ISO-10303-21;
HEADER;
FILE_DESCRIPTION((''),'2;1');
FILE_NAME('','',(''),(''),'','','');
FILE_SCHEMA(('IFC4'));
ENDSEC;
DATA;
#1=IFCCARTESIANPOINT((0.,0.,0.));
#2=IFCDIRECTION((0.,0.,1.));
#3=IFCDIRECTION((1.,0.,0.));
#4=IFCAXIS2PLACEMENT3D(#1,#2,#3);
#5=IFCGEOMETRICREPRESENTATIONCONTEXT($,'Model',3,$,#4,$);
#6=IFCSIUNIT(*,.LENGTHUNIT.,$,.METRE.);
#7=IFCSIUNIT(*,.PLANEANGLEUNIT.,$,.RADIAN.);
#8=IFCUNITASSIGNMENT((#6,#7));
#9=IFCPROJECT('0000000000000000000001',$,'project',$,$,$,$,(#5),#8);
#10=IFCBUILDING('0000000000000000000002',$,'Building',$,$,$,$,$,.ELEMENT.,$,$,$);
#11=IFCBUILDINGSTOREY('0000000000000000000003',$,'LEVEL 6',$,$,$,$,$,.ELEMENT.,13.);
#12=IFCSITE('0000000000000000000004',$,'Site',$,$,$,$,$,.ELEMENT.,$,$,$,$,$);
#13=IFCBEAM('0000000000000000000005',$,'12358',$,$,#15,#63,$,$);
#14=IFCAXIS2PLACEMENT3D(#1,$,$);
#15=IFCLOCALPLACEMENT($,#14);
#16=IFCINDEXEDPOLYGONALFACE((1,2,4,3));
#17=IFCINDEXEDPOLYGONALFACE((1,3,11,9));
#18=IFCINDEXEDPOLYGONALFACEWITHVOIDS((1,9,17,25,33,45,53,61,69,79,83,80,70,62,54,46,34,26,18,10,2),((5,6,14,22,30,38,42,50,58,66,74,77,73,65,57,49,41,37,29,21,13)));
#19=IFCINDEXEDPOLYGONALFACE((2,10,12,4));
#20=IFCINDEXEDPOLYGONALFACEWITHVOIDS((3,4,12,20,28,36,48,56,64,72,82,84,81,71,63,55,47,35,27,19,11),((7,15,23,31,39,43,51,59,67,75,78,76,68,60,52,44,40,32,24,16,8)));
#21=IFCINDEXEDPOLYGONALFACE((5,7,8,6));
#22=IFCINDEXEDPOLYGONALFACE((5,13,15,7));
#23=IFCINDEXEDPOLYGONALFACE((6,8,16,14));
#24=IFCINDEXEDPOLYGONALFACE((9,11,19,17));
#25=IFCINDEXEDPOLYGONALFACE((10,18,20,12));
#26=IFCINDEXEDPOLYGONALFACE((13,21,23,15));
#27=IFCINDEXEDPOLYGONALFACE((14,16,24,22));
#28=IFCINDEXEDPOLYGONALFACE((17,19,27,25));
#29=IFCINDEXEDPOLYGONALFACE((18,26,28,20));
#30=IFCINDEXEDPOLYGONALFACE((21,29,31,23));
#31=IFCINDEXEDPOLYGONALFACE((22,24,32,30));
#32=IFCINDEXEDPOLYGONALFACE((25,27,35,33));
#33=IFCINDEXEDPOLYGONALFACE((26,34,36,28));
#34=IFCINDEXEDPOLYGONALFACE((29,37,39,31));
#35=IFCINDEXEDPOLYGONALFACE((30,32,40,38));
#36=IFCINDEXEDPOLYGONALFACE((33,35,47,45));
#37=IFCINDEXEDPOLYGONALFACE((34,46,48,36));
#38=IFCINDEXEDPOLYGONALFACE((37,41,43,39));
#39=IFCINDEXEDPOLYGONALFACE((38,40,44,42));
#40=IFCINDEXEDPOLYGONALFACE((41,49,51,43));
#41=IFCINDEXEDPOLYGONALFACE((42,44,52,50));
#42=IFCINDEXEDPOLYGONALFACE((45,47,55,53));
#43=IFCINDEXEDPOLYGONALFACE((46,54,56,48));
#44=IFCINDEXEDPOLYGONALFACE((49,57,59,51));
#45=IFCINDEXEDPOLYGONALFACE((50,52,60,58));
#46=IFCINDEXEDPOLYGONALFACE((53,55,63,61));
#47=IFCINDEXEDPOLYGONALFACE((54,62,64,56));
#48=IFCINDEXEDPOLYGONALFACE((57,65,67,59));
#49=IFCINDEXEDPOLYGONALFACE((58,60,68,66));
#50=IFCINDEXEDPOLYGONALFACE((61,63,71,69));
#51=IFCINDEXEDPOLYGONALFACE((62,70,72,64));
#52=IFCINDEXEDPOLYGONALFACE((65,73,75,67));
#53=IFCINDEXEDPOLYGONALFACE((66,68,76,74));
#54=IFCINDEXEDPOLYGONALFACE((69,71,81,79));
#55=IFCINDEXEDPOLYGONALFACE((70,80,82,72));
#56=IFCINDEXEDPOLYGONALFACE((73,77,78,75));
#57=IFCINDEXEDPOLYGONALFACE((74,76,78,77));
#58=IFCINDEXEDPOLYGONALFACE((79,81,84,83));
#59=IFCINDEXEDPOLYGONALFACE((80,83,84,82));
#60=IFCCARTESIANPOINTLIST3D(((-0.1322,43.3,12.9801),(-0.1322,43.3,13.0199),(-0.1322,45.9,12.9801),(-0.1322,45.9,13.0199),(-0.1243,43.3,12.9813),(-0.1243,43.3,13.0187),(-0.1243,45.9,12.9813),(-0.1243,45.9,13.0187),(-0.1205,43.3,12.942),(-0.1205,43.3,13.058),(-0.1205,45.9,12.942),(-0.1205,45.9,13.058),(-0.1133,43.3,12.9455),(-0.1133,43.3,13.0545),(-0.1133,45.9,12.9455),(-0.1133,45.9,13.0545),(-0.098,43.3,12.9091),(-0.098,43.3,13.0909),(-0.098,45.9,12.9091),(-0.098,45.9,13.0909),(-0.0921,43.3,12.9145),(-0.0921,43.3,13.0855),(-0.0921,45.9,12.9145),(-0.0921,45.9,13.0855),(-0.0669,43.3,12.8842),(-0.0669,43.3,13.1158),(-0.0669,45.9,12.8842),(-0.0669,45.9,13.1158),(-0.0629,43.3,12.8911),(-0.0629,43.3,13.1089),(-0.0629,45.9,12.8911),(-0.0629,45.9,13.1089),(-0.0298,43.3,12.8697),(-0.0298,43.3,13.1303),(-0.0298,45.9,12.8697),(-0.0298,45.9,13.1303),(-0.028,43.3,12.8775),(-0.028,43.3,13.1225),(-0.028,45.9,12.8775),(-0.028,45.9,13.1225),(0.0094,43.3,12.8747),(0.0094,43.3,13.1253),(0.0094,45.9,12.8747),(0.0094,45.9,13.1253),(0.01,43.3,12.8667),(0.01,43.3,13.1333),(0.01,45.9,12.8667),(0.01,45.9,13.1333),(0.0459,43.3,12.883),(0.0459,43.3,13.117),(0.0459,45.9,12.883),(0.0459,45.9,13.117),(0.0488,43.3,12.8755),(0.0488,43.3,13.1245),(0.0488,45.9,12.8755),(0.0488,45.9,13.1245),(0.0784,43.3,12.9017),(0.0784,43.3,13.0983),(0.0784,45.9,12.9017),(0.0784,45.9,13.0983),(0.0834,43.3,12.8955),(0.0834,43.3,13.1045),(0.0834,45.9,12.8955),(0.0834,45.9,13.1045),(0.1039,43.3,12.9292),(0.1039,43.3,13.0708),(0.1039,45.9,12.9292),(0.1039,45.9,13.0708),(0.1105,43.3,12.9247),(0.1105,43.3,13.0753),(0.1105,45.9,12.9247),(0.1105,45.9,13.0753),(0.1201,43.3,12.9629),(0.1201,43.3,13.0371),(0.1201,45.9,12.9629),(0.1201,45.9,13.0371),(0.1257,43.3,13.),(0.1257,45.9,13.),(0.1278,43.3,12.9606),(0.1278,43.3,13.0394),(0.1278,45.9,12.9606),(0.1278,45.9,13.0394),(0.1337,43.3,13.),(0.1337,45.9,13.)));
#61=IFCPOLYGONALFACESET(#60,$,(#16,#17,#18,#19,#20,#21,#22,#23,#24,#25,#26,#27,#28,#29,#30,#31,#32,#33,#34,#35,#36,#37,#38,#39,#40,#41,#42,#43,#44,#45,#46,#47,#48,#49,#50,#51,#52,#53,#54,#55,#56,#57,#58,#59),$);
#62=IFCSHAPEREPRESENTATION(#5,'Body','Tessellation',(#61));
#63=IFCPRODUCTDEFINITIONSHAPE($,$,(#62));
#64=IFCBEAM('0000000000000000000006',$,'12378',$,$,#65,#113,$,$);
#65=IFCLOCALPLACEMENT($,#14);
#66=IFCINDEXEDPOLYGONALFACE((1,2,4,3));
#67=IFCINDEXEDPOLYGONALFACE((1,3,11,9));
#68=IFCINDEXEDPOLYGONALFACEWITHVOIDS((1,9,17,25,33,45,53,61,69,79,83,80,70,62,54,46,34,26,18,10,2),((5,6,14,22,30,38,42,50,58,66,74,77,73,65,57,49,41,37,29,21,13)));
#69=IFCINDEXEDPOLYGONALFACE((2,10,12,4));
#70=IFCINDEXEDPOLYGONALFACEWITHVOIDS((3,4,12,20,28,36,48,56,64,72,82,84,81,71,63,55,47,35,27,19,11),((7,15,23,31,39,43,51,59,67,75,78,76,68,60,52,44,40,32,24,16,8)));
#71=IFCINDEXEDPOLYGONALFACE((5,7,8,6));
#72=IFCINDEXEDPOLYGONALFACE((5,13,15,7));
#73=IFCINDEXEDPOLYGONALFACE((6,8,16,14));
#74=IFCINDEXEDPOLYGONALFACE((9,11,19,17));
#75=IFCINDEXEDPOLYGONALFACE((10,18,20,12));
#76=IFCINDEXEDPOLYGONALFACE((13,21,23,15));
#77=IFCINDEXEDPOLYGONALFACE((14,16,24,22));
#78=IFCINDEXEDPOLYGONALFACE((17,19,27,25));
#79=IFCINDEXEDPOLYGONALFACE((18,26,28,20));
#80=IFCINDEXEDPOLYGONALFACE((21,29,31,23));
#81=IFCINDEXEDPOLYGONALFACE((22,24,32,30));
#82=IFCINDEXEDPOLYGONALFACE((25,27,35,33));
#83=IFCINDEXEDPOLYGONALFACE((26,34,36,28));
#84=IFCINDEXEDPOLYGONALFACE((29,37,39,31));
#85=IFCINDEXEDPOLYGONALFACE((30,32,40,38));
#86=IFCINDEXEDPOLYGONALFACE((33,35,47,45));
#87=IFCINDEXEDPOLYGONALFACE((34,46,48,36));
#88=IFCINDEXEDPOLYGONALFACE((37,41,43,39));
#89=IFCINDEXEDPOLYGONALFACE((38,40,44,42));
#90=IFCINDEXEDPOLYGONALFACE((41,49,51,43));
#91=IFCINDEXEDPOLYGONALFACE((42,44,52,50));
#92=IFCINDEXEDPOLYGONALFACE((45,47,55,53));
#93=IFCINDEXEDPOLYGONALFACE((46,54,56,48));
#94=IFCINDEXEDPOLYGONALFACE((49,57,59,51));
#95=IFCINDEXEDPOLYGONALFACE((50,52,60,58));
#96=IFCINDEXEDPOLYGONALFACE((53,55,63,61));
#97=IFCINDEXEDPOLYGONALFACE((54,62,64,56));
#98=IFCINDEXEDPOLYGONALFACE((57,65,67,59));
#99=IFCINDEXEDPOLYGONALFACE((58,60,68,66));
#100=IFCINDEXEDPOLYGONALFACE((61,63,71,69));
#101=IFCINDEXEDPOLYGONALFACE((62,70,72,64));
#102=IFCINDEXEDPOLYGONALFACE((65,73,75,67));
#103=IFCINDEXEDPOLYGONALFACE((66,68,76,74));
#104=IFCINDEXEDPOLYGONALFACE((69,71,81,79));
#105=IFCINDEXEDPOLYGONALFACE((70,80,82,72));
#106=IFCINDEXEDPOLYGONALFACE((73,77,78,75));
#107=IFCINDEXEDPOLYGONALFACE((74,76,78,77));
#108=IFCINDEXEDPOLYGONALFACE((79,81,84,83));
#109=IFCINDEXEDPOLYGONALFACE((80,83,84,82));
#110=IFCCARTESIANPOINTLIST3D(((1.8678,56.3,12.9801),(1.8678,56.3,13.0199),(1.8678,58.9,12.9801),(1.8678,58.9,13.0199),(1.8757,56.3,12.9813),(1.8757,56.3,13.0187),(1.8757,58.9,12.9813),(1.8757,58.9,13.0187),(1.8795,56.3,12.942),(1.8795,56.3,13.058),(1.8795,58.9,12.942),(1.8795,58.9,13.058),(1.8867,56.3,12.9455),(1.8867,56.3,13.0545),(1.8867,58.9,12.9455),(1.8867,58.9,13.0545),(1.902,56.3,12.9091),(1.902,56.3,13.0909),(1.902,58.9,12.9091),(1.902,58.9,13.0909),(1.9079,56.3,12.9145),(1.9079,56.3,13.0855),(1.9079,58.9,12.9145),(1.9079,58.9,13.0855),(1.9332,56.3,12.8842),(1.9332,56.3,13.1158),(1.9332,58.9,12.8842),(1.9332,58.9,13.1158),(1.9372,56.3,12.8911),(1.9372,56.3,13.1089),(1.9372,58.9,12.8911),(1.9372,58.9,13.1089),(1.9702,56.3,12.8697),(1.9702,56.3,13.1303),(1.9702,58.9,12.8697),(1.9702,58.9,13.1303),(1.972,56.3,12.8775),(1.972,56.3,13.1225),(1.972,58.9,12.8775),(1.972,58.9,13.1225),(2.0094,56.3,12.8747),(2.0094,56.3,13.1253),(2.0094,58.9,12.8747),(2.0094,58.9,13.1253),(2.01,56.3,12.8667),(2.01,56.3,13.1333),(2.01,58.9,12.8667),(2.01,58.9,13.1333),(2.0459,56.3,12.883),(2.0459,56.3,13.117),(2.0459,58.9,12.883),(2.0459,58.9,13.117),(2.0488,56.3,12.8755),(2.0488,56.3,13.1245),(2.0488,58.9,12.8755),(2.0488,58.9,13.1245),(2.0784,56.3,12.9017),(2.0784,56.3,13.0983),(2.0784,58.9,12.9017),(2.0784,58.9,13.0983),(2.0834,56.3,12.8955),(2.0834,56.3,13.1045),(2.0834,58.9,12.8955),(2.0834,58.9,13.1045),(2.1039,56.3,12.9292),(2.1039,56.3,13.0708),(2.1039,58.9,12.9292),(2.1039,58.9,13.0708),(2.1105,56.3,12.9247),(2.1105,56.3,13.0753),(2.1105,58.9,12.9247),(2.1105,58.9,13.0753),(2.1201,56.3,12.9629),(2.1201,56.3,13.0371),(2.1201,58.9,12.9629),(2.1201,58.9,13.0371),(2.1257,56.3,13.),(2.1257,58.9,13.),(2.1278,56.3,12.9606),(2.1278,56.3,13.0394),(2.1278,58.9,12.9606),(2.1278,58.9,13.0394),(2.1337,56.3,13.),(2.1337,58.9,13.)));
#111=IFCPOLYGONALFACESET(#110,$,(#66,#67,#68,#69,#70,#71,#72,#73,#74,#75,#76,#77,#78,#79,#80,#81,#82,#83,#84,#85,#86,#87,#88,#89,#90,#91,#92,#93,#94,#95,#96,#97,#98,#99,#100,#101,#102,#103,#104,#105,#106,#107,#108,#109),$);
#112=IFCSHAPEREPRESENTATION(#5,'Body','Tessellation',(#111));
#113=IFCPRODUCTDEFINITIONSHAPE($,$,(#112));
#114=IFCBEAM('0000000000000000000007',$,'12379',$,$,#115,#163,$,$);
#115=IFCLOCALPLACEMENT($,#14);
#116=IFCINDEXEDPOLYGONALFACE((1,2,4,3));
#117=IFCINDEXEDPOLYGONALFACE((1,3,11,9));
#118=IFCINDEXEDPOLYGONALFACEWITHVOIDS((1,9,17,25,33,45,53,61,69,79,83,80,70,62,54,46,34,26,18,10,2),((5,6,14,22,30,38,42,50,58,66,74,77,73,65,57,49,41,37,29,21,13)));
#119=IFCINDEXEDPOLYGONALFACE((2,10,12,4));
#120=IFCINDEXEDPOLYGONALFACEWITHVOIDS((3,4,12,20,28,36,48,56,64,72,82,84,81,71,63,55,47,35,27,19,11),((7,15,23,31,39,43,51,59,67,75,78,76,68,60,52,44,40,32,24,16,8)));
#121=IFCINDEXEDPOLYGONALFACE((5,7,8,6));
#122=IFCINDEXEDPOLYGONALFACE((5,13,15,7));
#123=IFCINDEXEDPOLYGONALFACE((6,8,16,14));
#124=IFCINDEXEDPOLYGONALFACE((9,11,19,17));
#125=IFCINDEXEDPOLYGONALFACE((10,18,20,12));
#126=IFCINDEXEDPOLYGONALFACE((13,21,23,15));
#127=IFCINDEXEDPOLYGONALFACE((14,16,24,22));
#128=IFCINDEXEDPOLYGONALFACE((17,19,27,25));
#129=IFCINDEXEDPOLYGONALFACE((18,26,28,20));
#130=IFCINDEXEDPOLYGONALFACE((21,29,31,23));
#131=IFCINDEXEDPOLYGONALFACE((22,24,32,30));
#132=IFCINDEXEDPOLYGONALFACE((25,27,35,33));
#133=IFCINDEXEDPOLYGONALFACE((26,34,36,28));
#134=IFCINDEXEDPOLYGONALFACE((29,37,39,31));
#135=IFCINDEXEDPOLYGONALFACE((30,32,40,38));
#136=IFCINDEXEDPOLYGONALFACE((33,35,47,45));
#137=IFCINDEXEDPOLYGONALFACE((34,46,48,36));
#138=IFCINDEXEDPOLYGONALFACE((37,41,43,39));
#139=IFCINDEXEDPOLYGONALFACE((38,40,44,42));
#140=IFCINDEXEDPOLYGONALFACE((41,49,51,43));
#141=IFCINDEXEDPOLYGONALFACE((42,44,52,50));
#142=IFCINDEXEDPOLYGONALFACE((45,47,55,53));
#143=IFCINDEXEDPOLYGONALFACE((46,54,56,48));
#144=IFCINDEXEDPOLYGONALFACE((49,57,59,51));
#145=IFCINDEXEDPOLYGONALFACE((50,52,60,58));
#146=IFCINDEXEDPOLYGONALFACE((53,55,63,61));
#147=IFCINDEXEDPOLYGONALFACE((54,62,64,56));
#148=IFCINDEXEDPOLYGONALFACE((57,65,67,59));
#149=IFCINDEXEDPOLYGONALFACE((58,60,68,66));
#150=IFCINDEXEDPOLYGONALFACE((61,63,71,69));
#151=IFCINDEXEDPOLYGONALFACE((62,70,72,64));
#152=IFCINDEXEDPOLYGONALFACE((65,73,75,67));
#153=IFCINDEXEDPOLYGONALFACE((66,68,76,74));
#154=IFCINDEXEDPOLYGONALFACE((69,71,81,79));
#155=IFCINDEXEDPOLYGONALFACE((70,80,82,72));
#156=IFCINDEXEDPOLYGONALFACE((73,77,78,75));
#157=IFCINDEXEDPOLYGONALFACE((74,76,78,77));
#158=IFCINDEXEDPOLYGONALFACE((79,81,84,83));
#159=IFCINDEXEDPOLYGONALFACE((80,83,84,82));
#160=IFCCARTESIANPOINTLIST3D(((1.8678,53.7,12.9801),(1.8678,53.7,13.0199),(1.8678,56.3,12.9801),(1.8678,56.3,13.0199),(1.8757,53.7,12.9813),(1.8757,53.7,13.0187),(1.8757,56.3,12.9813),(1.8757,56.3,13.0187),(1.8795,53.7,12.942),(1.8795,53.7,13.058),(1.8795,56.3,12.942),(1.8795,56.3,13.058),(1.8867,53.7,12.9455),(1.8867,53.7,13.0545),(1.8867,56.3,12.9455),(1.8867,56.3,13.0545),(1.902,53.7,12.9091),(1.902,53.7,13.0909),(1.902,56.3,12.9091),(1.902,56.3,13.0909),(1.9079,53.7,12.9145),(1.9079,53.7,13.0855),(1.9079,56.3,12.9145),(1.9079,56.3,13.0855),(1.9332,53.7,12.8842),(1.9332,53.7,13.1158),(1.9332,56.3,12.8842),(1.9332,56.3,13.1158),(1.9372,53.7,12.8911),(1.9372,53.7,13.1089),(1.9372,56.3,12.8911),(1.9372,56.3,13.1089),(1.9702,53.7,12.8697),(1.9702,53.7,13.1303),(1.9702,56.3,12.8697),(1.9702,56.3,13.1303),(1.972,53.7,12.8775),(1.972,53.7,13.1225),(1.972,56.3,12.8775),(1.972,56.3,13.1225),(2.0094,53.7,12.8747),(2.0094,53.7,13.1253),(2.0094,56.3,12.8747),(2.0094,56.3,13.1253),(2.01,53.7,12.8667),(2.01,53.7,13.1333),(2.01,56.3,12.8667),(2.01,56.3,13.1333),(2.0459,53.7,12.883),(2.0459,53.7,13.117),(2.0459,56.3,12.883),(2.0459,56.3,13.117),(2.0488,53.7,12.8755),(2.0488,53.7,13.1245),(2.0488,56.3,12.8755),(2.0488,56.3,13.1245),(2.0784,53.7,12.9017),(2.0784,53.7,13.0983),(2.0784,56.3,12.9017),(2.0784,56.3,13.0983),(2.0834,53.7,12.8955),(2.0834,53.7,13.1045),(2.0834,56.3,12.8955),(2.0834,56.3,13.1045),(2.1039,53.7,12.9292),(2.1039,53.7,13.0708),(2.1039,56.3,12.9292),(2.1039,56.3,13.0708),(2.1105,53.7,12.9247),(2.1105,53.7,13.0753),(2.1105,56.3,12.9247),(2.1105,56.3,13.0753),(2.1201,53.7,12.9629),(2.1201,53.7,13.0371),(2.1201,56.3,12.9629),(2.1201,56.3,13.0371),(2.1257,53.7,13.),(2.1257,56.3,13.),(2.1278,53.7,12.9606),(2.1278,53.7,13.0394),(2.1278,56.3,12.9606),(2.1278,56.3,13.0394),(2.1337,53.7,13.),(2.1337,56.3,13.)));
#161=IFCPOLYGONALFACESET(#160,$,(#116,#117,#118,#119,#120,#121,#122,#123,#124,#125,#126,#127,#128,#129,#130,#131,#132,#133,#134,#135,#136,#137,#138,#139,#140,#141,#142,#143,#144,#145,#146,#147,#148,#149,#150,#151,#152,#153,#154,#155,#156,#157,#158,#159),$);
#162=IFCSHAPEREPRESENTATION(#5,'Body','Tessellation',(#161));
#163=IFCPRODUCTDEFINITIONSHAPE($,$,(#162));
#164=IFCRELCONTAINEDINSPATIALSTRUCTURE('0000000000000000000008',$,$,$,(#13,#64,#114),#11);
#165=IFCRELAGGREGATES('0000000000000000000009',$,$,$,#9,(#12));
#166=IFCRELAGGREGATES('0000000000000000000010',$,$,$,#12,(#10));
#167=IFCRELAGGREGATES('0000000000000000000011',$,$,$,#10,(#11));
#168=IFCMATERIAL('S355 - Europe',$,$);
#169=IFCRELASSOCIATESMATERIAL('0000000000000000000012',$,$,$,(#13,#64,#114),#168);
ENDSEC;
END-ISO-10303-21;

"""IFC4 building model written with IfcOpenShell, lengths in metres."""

from ifc_helpers import new_model, si_unit, frame, origin_with_axes, origin_2d_with_axis, place, context, project, spatial, hollow_circle, extrude, material, material_profile, profile_set, profile_usage, element, save


model = new_model("IFC4")

# Units and contexts
model_context = context("Model", 3, world=origin_with_axes())
ifc_project = project(units=[si_unit("LENGTHUNIT", "METRE"), si_unit("PLANEANGLEUNIT", "RADIAN")], contexts=[model_context])

# Site, building, storey
site = spatial("IfcSite", under=ifc_project, Name="Site", CompositionType="ELEMENT")
building = spatial("IfcBuilding", under=site, Name="Building", CompositionType="ELEMENT")
storey = spatial("IfcBuildingStorey", under=building, Name="LEVEL 6", CompositionType="ELEMENT", Elevation=13.0)

# Shared definitions
ifc_material = material(Name="S355 - Europe")

# Beams
ifc_material_profile_1 = material_profile(ifc_material, hollow_circle(Radius=0.1337, WallThickness=0.008, at=origin_2d_with_axis()))
ifc_profile_set_1 = profile_set([ifc_material_profile_1])
ifc_profile_usage_1 = profile_usage(ifc_profile_set_1, cardinal=10)
beam_1_placement = place(None, frame((0.0, 45.9, 13.0), z_axis=(0.0, -1.0, 0.0), x_axis=(1.0, 0.0, 0.0)))
element("IfcBeam", 1, at=beam_1_placement, inside=storey, material=ifc_profile_usage_1, Name="12358", context=model_context, shape_type="SweptSolid", body=[
    extrude(hollow_circle(Radius=0.1337, WallThickness=0.008, at=origin_2d_with_axis()), origin_with_axes(), (0.0, 0.0, 1.0), 2.6),
])
ifc_material_profile_2 = material_profile(ifc_material, hollow_circle(Radius=0.1337, WallThickness=0.008, at=origin_2d_with_axis()))
ifc_profile_set_2 = profile_set([ifc_material_profile_2])
ifc_profile_usage_2 = profile_usage(ifc_profile_set_2, cardinal=10)
beam_2_placement = place(None, frame((2.0, 58.9, 13.0), z_axis=(0.0, -1.0, 0.0), x_axis=(1.0, 0.0, 0.0)))
element("IfcBeam", 2, at=beam_2_placement, inside=storey, material=ifc_profile_usage_2, Name="12378", context=model_context, shape_type="SweptSolid", body=[
    extrude(hollow_circle(Radius=0.1337, WallThickness=0.008, at=origin_2d_with_axis()), origin_with_axes(), (0.0, 0.0, 1.0), 2.6),
])
ifc_material_profile_3 = material_profile(ifc_material, hollow_circle(Radius=0.1337, WallThickness=0.008, at=origin_2d_with_axis()))
ifc_profile_set_3 = profile_set([ifc_material_profile_3])
ifc_profile_usage_3 = profile_usage(ifc_profile_set_3, cardinal=10)
beam_3_placement = place(None, frame((2.0, 56.3, 13.0), z_axis=(0.0, -1.0, 0.0), x_axis=(1.0, 0.0, 0.0)))
element("IfcBeam", 3, at=beam_3_placement, inside=storey, material=ifc_profile_usage_3, Name="12379", context=model_context, shape_type="SweptSolid", body=[
    extrude(hollow_circle(Radius=0.1337, WallThickness=0.008, at=origin_2d_with_axis()), origin_with_axes(), (0.0, 0.0, 1.0), 2.6),
])

save(model, "model.ifc")
